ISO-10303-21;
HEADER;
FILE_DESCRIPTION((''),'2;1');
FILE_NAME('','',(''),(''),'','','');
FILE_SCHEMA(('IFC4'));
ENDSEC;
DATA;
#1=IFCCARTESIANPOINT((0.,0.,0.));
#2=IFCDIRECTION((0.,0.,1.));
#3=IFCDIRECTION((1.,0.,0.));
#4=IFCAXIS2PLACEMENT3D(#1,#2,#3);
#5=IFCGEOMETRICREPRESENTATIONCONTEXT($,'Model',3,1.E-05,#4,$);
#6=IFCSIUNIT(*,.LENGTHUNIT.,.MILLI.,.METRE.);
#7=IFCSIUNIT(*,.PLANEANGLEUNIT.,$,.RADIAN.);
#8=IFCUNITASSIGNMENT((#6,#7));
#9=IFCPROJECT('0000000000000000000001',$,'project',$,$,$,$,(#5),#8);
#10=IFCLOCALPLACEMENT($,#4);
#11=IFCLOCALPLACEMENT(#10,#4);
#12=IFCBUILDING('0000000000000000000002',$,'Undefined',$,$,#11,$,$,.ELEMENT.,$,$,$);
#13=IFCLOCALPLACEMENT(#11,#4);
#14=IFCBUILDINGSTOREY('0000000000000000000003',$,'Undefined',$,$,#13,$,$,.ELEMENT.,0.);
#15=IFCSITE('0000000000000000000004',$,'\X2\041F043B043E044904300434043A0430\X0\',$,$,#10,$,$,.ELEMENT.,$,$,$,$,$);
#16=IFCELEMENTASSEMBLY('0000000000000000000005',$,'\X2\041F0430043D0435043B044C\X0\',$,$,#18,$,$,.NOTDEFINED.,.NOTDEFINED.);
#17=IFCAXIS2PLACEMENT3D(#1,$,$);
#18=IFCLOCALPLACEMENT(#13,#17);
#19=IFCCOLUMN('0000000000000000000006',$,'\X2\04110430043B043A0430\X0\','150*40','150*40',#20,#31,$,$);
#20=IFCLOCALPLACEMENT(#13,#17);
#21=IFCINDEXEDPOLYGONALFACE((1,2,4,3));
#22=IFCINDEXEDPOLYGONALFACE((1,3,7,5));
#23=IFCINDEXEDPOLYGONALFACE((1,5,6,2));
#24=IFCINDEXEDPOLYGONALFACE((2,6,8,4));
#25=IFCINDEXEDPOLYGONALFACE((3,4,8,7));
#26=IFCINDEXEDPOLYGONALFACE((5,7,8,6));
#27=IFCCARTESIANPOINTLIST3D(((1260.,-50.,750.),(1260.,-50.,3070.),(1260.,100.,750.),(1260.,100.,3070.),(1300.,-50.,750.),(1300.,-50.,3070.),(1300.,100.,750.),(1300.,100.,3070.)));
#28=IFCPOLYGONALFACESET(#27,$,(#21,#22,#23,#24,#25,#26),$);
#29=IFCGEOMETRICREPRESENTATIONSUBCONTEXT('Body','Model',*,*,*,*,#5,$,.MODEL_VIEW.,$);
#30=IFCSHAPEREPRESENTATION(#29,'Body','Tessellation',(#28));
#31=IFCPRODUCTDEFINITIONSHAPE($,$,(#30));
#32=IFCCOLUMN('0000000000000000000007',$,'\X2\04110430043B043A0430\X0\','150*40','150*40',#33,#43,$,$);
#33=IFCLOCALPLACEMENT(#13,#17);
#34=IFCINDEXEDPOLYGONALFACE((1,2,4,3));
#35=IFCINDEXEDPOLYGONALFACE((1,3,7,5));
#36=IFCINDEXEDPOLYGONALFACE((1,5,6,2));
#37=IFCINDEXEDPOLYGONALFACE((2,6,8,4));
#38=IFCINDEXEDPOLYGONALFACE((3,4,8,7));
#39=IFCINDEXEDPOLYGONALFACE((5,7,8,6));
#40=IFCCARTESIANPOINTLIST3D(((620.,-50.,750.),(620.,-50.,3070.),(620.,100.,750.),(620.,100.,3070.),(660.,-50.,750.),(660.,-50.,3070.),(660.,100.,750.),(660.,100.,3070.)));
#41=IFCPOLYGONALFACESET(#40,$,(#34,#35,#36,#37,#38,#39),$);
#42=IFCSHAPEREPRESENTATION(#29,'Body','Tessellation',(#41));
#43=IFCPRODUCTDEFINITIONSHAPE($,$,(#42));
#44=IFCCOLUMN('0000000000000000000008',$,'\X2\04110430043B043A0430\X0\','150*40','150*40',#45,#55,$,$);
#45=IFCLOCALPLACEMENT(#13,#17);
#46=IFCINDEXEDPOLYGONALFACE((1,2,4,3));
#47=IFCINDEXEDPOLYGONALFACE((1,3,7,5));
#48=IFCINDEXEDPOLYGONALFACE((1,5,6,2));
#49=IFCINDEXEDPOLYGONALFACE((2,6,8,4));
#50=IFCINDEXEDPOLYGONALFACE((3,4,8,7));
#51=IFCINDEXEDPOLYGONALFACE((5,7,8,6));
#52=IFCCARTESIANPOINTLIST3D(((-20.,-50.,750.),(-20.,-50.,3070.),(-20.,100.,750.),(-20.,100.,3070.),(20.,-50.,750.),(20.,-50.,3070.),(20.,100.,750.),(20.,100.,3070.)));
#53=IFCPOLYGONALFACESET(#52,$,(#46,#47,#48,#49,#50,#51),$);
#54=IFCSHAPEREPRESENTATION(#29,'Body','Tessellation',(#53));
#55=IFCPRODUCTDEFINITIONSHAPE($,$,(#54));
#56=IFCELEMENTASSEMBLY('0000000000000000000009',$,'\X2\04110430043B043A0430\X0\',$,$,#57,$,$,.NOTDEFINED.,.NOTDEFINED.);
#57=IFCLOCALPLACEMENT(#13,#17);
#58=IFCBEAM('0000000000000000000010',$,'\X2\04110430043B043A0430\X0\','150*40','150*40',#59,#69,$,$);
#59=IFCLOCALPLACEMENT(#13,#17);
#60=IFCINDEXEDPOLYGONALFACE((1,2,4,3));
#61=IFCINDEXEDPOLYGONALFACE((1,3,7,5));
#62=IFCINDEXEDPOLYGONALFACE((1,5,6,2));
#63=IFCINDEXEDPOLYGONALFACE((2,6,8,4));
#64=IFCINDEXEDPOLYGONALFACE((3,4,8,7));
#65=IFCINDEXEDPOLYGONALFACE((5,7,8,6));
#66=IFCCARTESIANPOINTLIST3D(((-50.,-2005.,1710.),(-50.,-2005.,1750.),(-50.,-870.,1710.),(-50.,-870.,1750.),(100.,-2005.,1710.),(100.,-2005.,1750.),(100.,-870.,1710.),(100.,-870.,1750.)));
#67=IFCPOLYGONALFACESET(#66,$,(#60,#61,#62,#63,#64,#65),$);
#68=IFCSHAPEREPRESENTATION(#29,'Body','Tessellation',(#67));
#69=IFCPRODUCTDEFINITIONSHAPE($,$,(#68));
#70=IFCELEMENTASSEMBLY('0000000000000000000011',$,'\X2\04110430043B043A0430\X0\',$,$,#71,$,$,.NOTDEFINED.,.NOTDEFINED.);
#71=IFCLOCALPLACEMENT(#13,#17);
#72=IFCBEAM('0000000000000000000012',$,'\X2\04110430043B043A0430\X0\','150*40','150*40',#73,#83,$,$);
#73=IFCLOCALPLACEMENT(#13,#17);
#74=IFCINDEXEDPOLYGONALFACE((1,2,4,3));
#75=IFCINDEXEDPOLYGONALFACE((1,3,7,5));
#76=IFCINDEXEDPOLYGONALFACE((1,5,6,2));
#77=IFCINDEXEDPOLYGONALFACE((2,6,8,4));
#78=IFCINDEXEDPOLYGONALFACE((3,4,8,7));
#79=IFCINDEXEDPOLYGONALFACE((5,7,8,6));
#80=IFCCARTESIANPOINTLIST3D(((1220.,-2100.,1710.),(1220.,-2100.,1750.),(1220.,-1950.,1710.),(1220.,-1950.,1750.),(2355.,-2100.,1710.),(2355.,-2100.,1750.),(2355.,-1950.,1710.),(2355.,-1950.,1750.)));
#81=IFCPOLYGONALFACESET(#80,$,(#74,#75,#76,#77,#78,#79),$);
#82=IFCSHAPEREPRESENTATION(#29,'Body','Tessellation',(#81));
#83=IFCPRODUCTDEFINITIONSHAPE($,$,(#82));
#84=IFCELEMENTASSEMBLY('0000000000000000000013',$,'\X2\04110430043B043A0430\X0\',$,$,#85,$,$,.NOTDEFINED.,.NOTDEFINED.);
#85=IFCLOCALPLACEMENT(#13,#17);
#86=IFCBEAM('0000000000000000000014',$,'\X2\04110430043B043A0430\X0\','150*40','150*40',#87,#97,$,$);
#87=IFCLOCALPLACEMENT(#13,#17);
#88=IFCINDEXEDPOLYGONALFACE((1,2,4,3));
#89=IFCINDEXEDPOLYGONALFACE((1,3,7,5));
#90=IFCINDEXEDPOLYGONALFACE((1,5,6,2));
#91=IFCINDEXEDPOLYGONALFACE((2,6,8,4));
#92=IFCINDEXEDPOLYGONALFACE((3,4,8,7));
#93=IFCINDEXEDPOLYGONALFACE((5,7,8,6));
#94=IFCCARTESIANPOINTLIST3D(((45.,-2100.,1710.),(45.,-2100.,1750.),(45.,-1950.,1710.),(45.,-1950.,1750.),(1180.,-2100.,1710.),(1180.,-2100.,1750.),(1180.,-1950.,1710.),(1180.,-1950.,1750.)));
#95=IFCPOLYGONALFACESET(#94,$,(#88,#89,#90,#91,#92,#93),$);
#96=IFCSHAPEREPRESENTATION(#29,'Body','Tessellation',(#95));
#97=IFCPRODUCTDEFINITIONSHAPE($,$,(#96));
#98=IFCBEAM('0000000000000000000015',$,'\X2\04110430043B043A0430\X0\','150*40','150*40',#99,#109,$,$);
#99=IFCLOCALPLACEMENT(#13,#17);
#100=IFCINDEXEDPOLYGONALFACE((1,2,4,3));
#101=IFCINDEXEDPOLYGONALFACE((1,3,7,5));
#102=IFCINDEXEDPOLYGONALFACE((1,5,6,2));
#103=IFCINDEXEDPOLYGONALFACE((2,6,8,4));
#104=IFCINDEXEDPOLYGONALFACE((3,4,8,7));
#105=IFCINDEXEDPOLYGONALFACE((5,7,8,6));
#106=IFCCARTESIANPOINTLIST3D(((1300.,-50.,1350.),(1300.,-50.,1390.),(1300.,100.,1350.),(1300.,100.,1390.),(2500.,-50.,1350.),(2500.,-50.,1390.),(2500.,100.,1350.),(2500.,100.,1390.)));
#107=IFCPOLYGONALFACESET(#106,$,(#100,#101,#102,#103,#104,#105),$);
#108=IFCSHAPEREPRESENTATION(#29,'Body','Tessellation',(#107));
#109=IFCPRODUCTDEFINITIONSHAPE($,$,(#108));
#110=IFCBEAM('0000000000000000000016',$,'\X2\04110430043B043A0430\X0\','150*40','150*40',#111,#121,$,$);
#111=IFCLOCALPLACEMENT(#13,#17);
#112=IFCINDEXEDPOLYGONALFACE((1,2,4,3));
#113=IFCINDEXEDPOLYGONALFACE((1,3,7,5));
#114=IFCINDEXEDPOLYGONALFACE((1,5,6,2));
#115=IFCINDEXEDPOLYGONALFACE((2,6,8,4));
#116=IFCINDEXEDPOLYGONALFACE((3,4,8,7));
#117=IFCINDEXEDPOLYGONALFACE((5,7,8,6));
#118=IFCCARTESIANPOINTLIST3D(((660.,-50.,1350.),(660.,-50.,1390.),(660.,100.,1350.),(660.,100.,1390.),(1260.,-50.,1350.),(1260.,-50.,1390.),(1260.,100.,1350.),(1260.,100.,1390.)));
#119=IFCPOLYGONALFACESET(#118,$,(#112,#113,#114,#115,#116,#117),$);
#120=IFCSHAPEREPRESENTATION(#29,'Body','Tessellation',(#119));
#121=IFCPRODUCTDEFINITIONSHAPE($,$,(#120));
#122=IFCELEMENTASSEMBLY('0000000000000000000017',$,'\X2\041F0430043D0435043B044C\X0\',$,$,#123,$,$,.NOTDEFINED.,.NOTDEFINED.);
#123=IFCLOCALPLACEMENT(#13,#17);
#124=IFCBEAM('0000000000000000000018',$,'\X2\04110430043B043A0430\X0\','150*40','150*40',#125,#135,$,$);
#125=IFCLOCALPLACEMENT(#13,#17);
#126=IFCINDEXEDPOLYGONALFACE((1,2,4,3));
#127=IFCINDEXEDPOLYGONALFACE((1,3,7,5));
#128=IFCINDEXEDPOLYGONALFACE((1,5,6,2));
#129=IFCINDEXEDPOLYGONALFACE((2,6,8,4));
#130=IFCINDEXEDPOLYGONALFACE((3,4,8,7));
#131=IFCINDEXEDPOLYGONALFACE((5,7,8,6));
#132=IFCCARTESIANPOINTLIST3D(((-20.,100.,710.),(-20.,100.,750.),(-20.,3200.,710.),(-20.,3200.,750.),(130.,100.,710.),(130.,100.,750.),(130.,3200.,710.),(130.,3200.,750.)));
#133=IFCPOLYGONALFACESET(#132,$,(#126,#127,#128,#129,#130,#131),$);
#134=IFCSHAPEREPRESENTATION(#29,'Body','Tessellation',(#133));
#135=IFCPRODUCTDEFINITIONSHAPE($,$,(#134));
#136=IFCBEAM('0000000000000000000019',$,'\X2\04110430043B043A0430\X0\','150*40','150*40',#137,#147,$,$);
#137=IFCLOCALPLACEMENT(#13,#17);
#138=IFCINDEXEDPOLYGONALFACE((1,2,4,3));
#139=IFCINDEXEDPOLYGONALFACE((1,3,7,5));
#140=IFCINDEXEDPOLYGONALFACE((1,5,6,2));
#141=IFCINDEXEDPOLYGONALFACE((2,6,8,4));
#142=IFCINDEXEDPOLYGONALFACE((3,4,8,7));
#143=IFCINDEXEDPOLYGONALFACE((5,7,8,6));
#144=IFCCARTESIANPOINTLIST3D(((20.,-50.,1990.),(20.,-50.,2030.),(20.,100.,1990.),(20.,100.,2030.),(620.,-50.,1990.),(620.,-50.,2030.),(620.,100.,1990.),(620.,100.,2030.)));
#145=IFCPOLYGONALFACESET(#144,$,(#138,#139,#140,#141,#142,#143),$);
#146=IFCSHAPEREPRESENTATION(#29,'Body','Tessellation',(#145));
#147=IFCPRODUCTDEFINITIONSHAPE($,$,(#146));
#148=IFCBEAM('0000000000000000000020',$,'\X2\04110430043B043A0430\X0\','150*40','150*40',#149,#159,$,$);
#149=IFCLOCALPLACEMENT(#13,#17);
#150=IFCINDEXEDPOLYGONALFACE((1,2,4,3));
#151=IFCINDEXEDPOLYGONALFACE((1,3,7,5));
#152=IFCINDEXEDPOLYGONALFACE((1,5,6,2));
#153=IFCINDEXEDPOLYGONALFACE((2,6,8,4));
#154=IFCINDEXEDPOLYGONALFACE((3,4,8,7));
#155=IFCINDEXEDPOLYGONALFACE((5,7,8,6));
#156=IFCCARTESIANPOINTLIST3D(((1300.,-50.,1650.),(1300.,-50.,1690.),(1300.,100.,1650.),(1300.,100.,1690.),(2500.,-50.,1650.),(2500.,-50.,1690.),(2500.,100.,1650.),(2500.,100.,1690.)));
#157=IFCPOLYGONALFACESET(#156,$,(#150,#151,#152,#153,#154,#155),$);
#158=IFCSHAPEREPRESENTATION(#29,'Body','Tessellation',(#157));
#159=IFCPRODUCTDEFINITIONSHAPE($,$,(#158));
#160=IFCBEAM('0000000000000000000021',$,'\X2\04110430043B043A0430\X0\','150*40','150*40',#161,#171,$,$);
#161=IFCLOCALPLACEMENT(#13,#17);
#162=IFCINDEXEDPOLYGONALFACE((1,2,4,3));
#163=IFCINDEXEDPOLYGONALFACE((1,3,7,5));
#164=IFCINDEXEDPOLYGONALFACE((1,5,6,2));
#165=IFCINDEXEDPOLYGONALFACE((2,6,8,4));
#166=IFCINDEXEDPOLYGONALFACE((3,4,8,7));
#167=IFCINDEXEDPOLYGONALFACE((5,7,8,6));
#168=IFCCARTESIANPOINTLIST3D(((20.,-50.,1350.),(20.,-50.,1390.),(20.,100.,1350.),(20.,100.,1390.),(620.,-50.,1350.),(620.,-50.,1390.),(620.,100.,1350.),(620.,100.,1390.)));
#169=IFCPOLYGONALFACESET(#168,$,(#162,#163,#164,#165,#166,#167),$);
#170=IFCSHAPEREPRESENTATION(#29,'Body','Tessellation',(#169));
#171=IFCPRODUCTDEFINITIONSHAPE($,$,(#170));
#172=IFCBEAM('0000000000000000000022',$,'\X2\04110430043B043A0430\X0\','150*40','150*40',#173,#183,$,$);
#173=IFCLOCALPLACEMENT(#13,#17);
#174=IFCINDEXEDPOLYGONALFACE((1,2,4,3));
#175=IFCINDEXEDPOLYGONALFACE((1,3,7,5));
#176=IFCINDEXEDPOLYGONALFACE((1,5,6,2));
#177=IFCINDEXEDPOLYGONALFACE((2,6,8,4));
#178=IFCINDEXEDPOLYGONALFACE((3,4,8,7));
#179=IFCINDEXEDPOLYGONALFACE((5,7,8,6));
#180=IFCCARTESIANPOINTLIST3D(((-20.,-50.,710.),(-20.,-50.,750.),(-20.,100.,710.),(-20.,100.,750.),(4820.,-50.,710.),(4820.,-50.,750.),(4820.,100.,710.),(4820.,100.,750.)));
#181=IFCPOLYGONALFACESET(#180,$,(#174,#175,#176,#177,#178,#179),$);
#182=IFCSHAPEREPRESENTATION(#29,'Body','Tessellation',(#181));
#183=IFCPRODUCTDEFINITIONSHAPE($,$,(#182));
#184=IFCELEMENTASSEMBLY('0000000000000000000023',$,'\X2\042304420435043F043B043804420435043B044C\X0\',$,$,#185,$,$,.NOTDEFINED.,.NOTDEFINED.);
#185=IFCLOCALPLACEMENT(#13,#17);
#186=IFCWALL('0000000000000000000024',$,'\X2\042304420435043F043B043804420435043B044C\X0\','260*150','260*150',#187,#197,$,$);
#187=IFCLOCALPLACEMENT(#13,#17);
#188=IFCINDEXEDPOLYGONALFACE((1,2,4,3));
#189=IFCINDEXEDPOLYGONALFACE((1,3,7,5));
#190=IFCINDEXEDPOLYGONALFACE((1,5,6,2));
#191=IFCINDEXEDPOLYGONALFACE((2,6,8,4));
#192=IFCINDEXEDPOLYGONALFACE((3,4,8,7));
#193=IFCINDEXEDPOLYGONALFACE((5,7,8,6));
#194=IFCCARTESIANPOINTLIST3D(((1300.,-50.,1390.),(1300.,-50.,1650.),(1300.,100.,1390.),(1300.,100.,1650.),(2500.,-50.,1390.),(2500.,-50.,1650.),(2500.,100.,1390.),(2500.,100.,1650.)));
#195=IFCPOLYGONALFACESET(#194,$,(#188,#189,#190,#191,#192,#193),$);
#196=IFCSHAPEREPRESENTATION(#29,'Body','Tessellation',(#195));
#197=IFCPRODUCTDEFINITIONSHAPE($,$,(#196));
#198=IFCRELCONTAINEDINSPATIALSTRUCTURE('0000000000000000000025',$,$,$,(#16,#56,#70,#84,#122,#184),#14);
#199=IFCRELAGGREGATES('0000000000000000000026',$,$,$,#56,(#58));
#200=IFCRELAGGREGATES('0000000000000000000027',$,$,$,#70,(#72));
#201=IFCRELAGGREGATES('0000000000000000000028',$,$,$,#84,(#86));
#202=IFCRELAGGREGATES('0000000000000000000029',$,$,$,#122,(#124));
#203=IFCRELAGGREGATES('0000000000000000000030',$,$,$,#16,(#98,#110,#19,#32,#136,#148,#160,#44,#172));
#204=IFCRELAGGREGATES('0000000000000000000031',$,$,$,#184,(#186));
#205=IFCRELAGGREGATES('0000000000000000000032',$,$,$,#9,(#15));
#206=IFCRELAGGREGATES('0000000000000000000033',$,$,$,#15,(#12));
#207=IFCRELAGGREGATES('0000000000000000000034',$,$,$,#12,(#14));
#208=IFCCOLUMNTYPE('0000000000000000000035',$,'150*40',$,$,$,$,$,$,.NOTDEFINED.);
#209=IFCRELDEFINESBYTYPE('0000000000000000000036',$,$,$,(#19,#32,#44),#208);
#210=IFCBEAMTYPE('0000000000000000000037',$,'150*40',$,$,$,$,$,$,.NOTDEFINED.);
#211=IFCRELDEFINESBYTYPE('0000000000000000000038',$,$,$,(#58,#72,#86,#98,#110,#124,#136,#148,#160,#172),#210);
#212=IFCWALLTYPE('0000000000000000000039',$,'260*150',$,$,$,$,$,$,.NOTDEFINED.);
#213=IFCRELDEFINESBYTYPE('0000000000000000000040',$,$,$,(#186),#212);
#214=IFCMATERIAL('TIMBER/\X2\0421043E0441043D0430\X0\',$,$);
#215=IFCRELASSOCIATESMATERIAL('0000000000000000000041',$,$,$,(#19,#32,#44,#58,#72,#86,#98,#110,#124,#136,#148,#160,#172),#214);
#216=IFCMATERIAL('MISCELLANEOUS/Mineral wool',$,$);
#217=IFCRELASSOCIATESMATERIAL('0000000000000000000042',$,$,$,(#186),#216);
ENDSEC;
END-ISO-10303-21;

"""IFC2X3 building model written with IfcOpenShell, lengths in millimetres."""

from ifc_helpers import new_model, si_unit, frame, frame_2d, origin_with_axes, origin_2d_with_axis, place, context, subcontext, project, spatial, rectangle, extrude, material, type_object, element, aggregate, save


model = new_model("IFC2X3")

# Units and contexts
model_context = context("Model", 3, precision=1e-05, world=origin_with_axes())
body_context = subcontext(model_context, "Body", "Model", "MODEL_VIEW")
ifc_project = project(units=[si_unit("LENGTHUNIT", "METRE", prefix="MILLI"), si_unit("PLANEANGLEUNIT", "RADIAN")], contexts=[model_context])

# Site, building, storey
site_placement = place(None, origin_with_axes())
site = spatial("IfcSite", under=ifc_project, at=site_placement, Name="Площадка", CompositionType="ELEMENT")
building_placement = place(site_placement, origin_with_axes())
building = spatial("IfcBuilding", under=site, at=building_placement, Name="Undefined", CompositionType="ELEMENT")
storey_placement = place(building_placement, origin_with_axes())
storey = spatial("IfcBuildingStorey", under=building, at=storey_placement, Name="Undefined", CompositionType="ELEMENT", Elevation=0.0)

# Element assembly, columns
assembly_1_placement = place(storey_placement, origin_with_axes())
assembly_1 = element("IfcElementAssembly", 1, at=assembly_1_placement, inside=storey, Name="Панель", AssemblyPlace="NOTDEFINED", PredefinedType="NOTDEFINED")
ifc_material_1 = material(Name="TIMBER/Сосна")
column_type = type_object("IfcColumnType", Name="150*40", PredefinedType="NOTDEFINED")
column_1_placement = place(assembly_1_placement, frame((1280.0, 25.0, 750.0), z_axis=(0.0, 0.0, 1.0), x_axis=(0.0, 1.0, 0.0)))
column_1 = element("IfcColumn", 2, at=column_1_placement, type_object=column_type, material=ifc_material_1, Name="Балка", Description="150*40", ObjectType="150*40", context=body_context, shape_type="SweptSolid", body=[
    extrude(rectangle(XDim=40.0, YDim=150.0, at=origin_2d_with_axis()), frame((0.0, 0.0, 2320.0), z_axis=(0.0, 0.0, -1.0), x_axis=(0.0, 1.0, 0.0)), (0.0, 0.0, 1.0), 2320.0),
])
column_2_placement = place(assembly_1_placement, frame((640.0, 25.0, 750.0), z_axis=(0.0, 0.0, 1.0), x_axis=(0.0, 1.0, 0.0)))
column_2 = element("IfcColumn", 3, at=column_2_placement, type_object=column_type, material=ifc_material_1, Name="Балка", Description="150*40", ObjectType="150*40", context=body_context, shape_type="SweptSolid", body=[
    extrude(rectangle(XDim=40.0, YDim=150.0, at=origin_2d_with_axis()), frame((0.0, 0.0, 2320.0), z_axis=(0.0, 0.0, -1.0), x_axis=(0.0, 1.0, 0.0)), (0.0, 0.0, 1.0), 2320.0),
])
column_3_placement = place(assembly_1_placement, frame((0.0, 25.0, 750.0), z_axis=(0.0, 0.0, 1.0), x_axis=(0.0, 1.0, 0.0)))
column_3 = element("IfcColumn", 4, at=column_3_placement, type_object=column_type, material=ifc_material_1, Name="Балка", Description="150*40", ObjectType="150*40", context=body_context, shape_type="SweptSolid", body=[
    extrude(rectangle(XDim=40.0, YDim=150.0, at=origin_2d_with_axis()), frame((0.0, 0.0, 2320.0), z_axis=(0.0, 0.0, -1.0), x_axis=(0.0, 1.0, 0.0)), (0.0, 0.0, 1.0), 2320.0),
])

# Element assemblies, beams
assembly_2_placement = place(storey_placement, origin_with_axes())
assembly_2 = element("IfcElementAssembly", 5, at=assembly_2_placement, inside=storey, Name="Балка", AssemblyPlace="NOTDEFINED", PredefinedType="NOTDEFINED")
beam_type_1 = type_object("IfcBeamType", Name="150*40", PredefinedType="NOTDEFINED")
beam_1_placement = place(assembly_2_placement, frame((25.0, -2005.0, 1730.0), z_axis=(-1.0, 0.0, 0.0), x_axis=(0.0, 1.0, 0.0)))
beam_1 = element("IfcBeam", 6, at=beam_1_placement, type_object=beam_type_1, material=ifc_material_1, Name="Балка", Description="150*40", ObjectType="150*40", context=body_context, shape_type="SweptSolid", body=[
    extrude(rectangle(XDim=40.0, YDim=150.0, at=origin_2d_with_axis()), frame((1135.0, 0.0, 0.0), z_axis=(-1.0, 0.0, 0.0), x_axis=(0.0, -1.0, 0.0)), (0.0, 0.0, 1.0), 1135.0),
])
aggregate(assembly_2, [beam_1])
assembly_3_placement = place(storey_placement, origin_with_axes())
assembly_3 = element("IfcElementAssembly", 7, at=assembly_3_placement, inside=storey, Name="Балка", AssemblyPlace="NOTDEFINED", PredefinedType="NOTDEFINED")
beam_2_placement = place(assembly_3_placement, frame((1220.0, -2025.0, 1730.0), z_axis=(0.0, 1.0, 0.0), x_axis=(1.0, 0.0, 0.0)))
beam_2 = element("IfcBeam", 8, at=beam_2_placement, type_object=beam_type_1, material=ifc_material_1, Name="Балка", Description="150*40", ObjectType="150*40", context=body_context, shape_type="SweptSolid", body=[
    extrude(rectangle(XDim=40.0, YDim=150.0, at=origin_2d_with_axis()), frame((1135.0, 0.0, 0.0), z_axis=(-1.0, 0.0, 0.0), x_axis=(0.0, -1.0, 0.0)), (0.0, 0.0, 1.0), 1135.0),
])
aggregate(assembly_3, [beam_2])
assembly_4_placement = place(storey_placement, origin_with_axes())
assembly_4 = element("IfcElementAssembly", 9, at=assembly_4_placement, inside=storey, Name="Балка", AssemblyPlace="NOTDEFINED", PredefinedType="NOTDEFINED")
beam_3_placement = place(assembly_4_placement, frame((45.0, -2025.0, 1730.0), z_axis=(0.0, 1.0, 0.0), x_axis=(1.0, 0.0, 0.0)))
beam_3 = element("IfcBeam", 10, at=beam_3_placement, type_object=beam_type_1, material=ifc_material_1, Name="Балка", Description="150*40", ObjectType="150*40", context=body_context, shape_type="SweptSolid", body=[
    extrude(rectangle(XDim=40.0, YDim=150.0, at=origin_2d_with_axis()), frame((1135.0, 0.0, 0.0), z_axis=(-1.0, 0.0, 0.0), x_axis=(0.0, -1.0, 0.0)), (0.0, 0.0, 1.0), 1135.0),
])
aggregate(assembly_4, [beam_3])

# Beams
beam_4_placement = place(assembly_1_placement, frame((1300.0, 25.0, 1370.0), z_axis=(0.0, 1.0, 0.0), x_axis=(1.0, 0.0, 0.0)))
beam_4 = element("IfcBeam", 11, at=beam_4_placement, type_object=beam_type_1, material=ifc_material_1, Name="Балка", Description="150*40", ObjectType="150*40", context=body_context, shape_type="SweptSolid", body=[
    extrude(rectangle(XDim=40.0, YDim=150.0, at=origin_2d_with_axis()), frame((1200.0, 0.0, 0.0), z_axis=(-1.0, 0.0, 0.0), x_axis=(0.0, -1.0, 0.0)), (0.0, 0.0, 1.0), 1200.0),
])
beam_5_placement = place(assembly_1_placement, frame((660.0, 25.0, 1370.0), z_axis=(0.0, 1.0, 0.0), x_axis=(1.0, 0.0, 0.0)))
beam_5 = element("IfcBeam", 12, at=beam_5_placement, type_object=beam_type_1, material=ifc_material_1, Name="Балка", Description="150*40", ObjectType="150*40", context=body_context, shape_type="SweptSolid", body=[
    extrude(rectangle(XDim=40.0, YDim=150.0, at=origin_2d_with_axis()), frame((600.0, 0.0, 0.0), z_axis=(-1.0, 0.0, 0.0), x_axis=(0.0, -1.0, 0.0)), (0.0, 0.0, 1.0), 600.0),
])

# Element assembly, beam
assembly_5_placement = place(storey_placement, origin_with_axes())
assembly_5 = element("IfcElementAssembly", 13, at=assembly_5_placement, inside=storey, Name="Панель", AssemblyPlace="NOTDEFINED", PredefinedType="NOTDEFINED")
beam_6_placement = place(assembly_5_placement, frame((55.0, 100.0, 730.0), z_axis=(-1.0, 0.0, 0.0), x_axis=(0.0, 1.0, 0.0)))
beam_6 = element("IfcBeam", 14, at=beam_6_placement, type_object=beam_type_1, material=ifc_material_1, Name="Балка", Description="150*40", ObjectType="150*40", context=body_context, shape_type="SweptSolid", body=[
    extrude(rectangle(XDim=40.0, YDim=150.0, at=origin_2d_with_axis()), frame((3100.0, 0.0, 0.0), z_axis=(-1.0, 0.0, 0.0), x_axis=(0.0, -1.0, 0.0)), (0.0, 0.0, 1.0), 3100.0),
])
aggregate(assembly_5, [beam_6])

# Beams
beam_7_placement = place(assembly_1_placement, frame((20.0, 25.0, 2010.0), z_axis=(0.0, 1.0, 0.0), x_axis=(1.0, 0.0, 0.0)))
beam_7 = element("IfcBeam", 15, at=beam_7_placement, type_object=beam_type_1, material=ifc_material_1, Name="Балка", Description="150*40", ObjectType="150*40", context=body_context, shape_type="SweptSolid", body=[
    extrude(rectangle(XDim=40.0, YDim=150.0, at=origin_2d_with_axis()), frame((600.0, 0.0, 0.0), z_axis=(-1.0, 0.0, 0.0), x_axis=(0.0, -1.0, 0.0)), (0.0, 0.0, 1.0), 600.0),
])
beam_8_placement = place(assembly_1_placement, frame((1300.0, 25.0, 1670.0), z_axis=(0.0, 1.0, 0.0), x_axis=(1.0, 0.0, 0.0)))
beam_8 = element("IfcBeam", 16, at=beam_8_placement, type_object=beam_type_1, material=ifc_material_1, Name="Балка", Description="150*40", ObjectType="150*40", context=body_context, shape_type="SweptSolid", body=[
    extrude(rectangle(XDim=40.0, YDim=150.0, at=origin_2d_with_axis()), frame((1200.0, 0.0, 0.0), z_axis=(-1.0, 0.0, 0.0), x_axis=(0.0, -1.0, 0.0)), (0.0, 0.0, 1.0), 1200.0),
])
beam_9_placement = place(assembly_1_placement, frame((20.0, 25.0, 1370.0), z_axis=(0.0, 1.0, 0.0), x_axis=(1.0, 0.0, 0.0)))
beam_9 = element("IfcBeam", 17, at=beam_9_placement, type_object=beam_type_1, material=ifc_material_1, Name="Балка", Description="150*40", ObjectType="150*40", context=body_context, shape_type="SweptSolid", body=[
    extrude(rectangle(XDim=40.0, YDim=150.0, at=origin_2d_with_axis()), frame((600.0, 0.0, 0.0), z_axis=(-1.0, 0.0, 0.0), x_axis=(0.0, -1.0, 0.0)), (0.0, 0.0, 1.0), 600.0),
])
beam_10_placement = place(assembly_1_placement, frame((-20.0, 25.0, 730.0), z_axis=(0.0, 1.0, 0.0), x_axis=(1.0, 0.0, 0.0)))
beam_10 = element("IfcBeam", 18, at=beam_10_placement, type_object=beam_type_1, material=ifc_material_1, Name="Балка", Description="150*40", ObjectType="150*40", context=body_context, shape_type="SweptSolid", body=[
    extrude(rectangle(XDim=40.0, YDim=150.0, at=origin_2d_with_axis()), frame((4840.0, 0.0, 0.0), z_axis=(-1.0, 0.0, 0.0), x_axis=(0.0, -1.0, 0.0)), (0.0, 0.0, 1.0), 4840.0),
])
aggregate(assembly_1, [beam_4, beam_5, column_1, column_2, beam_7, beam_8, beam_9, column_3, beam_10])

# Element assembly, wall
assembly_6_placement = place(storey_placement, origin_with_axes())
assembly_6 = element("IfcElementAssembly", 19, at=assembly_6_placement, inside=storey, Name="Утеплитель", AssemblyPlace="NOTDEFINED", PredefinedType="NOTDEFINED")
ifc_material_2 = material(Name="MISCELLANEOUS/Mineral wool")
wall_type_1 = type_object("IfcWallType", Name="260*150", PredefinedType="NOTDEFINED")
wall_1_placement = place(assembly_6_placement, frame((1300.0, 25.0, 1390.0), z_axis=(0.0, 0.0, 1.0), x_axis=(1.0, 0.0, 0.0)))
wall_1 = element("IfcWall", 20, at=wall_1_placement, type_object=wall_type_1, material=ifc_material_2, Name="Утеплитель", Description="260*150", ObjectType="260*150", context=body_context, shape_type="SweptSolid", body=[
    extrude(rectangle(XDim=1200.0, YDim=150.0, at=frame_2d((0.0, 600.0), x_axis=(0.0, -1.0))), frame((0.0, 0.0, 0.0), z_axis=(0.0, 0.0, 1.0), x_axis=(0.0, -1.0, 0.0)), (0.0, 0.0, 1.0), 260.0),
])
aggregate(assembly_6, [wall_1])

save(model, "model.ifc")
